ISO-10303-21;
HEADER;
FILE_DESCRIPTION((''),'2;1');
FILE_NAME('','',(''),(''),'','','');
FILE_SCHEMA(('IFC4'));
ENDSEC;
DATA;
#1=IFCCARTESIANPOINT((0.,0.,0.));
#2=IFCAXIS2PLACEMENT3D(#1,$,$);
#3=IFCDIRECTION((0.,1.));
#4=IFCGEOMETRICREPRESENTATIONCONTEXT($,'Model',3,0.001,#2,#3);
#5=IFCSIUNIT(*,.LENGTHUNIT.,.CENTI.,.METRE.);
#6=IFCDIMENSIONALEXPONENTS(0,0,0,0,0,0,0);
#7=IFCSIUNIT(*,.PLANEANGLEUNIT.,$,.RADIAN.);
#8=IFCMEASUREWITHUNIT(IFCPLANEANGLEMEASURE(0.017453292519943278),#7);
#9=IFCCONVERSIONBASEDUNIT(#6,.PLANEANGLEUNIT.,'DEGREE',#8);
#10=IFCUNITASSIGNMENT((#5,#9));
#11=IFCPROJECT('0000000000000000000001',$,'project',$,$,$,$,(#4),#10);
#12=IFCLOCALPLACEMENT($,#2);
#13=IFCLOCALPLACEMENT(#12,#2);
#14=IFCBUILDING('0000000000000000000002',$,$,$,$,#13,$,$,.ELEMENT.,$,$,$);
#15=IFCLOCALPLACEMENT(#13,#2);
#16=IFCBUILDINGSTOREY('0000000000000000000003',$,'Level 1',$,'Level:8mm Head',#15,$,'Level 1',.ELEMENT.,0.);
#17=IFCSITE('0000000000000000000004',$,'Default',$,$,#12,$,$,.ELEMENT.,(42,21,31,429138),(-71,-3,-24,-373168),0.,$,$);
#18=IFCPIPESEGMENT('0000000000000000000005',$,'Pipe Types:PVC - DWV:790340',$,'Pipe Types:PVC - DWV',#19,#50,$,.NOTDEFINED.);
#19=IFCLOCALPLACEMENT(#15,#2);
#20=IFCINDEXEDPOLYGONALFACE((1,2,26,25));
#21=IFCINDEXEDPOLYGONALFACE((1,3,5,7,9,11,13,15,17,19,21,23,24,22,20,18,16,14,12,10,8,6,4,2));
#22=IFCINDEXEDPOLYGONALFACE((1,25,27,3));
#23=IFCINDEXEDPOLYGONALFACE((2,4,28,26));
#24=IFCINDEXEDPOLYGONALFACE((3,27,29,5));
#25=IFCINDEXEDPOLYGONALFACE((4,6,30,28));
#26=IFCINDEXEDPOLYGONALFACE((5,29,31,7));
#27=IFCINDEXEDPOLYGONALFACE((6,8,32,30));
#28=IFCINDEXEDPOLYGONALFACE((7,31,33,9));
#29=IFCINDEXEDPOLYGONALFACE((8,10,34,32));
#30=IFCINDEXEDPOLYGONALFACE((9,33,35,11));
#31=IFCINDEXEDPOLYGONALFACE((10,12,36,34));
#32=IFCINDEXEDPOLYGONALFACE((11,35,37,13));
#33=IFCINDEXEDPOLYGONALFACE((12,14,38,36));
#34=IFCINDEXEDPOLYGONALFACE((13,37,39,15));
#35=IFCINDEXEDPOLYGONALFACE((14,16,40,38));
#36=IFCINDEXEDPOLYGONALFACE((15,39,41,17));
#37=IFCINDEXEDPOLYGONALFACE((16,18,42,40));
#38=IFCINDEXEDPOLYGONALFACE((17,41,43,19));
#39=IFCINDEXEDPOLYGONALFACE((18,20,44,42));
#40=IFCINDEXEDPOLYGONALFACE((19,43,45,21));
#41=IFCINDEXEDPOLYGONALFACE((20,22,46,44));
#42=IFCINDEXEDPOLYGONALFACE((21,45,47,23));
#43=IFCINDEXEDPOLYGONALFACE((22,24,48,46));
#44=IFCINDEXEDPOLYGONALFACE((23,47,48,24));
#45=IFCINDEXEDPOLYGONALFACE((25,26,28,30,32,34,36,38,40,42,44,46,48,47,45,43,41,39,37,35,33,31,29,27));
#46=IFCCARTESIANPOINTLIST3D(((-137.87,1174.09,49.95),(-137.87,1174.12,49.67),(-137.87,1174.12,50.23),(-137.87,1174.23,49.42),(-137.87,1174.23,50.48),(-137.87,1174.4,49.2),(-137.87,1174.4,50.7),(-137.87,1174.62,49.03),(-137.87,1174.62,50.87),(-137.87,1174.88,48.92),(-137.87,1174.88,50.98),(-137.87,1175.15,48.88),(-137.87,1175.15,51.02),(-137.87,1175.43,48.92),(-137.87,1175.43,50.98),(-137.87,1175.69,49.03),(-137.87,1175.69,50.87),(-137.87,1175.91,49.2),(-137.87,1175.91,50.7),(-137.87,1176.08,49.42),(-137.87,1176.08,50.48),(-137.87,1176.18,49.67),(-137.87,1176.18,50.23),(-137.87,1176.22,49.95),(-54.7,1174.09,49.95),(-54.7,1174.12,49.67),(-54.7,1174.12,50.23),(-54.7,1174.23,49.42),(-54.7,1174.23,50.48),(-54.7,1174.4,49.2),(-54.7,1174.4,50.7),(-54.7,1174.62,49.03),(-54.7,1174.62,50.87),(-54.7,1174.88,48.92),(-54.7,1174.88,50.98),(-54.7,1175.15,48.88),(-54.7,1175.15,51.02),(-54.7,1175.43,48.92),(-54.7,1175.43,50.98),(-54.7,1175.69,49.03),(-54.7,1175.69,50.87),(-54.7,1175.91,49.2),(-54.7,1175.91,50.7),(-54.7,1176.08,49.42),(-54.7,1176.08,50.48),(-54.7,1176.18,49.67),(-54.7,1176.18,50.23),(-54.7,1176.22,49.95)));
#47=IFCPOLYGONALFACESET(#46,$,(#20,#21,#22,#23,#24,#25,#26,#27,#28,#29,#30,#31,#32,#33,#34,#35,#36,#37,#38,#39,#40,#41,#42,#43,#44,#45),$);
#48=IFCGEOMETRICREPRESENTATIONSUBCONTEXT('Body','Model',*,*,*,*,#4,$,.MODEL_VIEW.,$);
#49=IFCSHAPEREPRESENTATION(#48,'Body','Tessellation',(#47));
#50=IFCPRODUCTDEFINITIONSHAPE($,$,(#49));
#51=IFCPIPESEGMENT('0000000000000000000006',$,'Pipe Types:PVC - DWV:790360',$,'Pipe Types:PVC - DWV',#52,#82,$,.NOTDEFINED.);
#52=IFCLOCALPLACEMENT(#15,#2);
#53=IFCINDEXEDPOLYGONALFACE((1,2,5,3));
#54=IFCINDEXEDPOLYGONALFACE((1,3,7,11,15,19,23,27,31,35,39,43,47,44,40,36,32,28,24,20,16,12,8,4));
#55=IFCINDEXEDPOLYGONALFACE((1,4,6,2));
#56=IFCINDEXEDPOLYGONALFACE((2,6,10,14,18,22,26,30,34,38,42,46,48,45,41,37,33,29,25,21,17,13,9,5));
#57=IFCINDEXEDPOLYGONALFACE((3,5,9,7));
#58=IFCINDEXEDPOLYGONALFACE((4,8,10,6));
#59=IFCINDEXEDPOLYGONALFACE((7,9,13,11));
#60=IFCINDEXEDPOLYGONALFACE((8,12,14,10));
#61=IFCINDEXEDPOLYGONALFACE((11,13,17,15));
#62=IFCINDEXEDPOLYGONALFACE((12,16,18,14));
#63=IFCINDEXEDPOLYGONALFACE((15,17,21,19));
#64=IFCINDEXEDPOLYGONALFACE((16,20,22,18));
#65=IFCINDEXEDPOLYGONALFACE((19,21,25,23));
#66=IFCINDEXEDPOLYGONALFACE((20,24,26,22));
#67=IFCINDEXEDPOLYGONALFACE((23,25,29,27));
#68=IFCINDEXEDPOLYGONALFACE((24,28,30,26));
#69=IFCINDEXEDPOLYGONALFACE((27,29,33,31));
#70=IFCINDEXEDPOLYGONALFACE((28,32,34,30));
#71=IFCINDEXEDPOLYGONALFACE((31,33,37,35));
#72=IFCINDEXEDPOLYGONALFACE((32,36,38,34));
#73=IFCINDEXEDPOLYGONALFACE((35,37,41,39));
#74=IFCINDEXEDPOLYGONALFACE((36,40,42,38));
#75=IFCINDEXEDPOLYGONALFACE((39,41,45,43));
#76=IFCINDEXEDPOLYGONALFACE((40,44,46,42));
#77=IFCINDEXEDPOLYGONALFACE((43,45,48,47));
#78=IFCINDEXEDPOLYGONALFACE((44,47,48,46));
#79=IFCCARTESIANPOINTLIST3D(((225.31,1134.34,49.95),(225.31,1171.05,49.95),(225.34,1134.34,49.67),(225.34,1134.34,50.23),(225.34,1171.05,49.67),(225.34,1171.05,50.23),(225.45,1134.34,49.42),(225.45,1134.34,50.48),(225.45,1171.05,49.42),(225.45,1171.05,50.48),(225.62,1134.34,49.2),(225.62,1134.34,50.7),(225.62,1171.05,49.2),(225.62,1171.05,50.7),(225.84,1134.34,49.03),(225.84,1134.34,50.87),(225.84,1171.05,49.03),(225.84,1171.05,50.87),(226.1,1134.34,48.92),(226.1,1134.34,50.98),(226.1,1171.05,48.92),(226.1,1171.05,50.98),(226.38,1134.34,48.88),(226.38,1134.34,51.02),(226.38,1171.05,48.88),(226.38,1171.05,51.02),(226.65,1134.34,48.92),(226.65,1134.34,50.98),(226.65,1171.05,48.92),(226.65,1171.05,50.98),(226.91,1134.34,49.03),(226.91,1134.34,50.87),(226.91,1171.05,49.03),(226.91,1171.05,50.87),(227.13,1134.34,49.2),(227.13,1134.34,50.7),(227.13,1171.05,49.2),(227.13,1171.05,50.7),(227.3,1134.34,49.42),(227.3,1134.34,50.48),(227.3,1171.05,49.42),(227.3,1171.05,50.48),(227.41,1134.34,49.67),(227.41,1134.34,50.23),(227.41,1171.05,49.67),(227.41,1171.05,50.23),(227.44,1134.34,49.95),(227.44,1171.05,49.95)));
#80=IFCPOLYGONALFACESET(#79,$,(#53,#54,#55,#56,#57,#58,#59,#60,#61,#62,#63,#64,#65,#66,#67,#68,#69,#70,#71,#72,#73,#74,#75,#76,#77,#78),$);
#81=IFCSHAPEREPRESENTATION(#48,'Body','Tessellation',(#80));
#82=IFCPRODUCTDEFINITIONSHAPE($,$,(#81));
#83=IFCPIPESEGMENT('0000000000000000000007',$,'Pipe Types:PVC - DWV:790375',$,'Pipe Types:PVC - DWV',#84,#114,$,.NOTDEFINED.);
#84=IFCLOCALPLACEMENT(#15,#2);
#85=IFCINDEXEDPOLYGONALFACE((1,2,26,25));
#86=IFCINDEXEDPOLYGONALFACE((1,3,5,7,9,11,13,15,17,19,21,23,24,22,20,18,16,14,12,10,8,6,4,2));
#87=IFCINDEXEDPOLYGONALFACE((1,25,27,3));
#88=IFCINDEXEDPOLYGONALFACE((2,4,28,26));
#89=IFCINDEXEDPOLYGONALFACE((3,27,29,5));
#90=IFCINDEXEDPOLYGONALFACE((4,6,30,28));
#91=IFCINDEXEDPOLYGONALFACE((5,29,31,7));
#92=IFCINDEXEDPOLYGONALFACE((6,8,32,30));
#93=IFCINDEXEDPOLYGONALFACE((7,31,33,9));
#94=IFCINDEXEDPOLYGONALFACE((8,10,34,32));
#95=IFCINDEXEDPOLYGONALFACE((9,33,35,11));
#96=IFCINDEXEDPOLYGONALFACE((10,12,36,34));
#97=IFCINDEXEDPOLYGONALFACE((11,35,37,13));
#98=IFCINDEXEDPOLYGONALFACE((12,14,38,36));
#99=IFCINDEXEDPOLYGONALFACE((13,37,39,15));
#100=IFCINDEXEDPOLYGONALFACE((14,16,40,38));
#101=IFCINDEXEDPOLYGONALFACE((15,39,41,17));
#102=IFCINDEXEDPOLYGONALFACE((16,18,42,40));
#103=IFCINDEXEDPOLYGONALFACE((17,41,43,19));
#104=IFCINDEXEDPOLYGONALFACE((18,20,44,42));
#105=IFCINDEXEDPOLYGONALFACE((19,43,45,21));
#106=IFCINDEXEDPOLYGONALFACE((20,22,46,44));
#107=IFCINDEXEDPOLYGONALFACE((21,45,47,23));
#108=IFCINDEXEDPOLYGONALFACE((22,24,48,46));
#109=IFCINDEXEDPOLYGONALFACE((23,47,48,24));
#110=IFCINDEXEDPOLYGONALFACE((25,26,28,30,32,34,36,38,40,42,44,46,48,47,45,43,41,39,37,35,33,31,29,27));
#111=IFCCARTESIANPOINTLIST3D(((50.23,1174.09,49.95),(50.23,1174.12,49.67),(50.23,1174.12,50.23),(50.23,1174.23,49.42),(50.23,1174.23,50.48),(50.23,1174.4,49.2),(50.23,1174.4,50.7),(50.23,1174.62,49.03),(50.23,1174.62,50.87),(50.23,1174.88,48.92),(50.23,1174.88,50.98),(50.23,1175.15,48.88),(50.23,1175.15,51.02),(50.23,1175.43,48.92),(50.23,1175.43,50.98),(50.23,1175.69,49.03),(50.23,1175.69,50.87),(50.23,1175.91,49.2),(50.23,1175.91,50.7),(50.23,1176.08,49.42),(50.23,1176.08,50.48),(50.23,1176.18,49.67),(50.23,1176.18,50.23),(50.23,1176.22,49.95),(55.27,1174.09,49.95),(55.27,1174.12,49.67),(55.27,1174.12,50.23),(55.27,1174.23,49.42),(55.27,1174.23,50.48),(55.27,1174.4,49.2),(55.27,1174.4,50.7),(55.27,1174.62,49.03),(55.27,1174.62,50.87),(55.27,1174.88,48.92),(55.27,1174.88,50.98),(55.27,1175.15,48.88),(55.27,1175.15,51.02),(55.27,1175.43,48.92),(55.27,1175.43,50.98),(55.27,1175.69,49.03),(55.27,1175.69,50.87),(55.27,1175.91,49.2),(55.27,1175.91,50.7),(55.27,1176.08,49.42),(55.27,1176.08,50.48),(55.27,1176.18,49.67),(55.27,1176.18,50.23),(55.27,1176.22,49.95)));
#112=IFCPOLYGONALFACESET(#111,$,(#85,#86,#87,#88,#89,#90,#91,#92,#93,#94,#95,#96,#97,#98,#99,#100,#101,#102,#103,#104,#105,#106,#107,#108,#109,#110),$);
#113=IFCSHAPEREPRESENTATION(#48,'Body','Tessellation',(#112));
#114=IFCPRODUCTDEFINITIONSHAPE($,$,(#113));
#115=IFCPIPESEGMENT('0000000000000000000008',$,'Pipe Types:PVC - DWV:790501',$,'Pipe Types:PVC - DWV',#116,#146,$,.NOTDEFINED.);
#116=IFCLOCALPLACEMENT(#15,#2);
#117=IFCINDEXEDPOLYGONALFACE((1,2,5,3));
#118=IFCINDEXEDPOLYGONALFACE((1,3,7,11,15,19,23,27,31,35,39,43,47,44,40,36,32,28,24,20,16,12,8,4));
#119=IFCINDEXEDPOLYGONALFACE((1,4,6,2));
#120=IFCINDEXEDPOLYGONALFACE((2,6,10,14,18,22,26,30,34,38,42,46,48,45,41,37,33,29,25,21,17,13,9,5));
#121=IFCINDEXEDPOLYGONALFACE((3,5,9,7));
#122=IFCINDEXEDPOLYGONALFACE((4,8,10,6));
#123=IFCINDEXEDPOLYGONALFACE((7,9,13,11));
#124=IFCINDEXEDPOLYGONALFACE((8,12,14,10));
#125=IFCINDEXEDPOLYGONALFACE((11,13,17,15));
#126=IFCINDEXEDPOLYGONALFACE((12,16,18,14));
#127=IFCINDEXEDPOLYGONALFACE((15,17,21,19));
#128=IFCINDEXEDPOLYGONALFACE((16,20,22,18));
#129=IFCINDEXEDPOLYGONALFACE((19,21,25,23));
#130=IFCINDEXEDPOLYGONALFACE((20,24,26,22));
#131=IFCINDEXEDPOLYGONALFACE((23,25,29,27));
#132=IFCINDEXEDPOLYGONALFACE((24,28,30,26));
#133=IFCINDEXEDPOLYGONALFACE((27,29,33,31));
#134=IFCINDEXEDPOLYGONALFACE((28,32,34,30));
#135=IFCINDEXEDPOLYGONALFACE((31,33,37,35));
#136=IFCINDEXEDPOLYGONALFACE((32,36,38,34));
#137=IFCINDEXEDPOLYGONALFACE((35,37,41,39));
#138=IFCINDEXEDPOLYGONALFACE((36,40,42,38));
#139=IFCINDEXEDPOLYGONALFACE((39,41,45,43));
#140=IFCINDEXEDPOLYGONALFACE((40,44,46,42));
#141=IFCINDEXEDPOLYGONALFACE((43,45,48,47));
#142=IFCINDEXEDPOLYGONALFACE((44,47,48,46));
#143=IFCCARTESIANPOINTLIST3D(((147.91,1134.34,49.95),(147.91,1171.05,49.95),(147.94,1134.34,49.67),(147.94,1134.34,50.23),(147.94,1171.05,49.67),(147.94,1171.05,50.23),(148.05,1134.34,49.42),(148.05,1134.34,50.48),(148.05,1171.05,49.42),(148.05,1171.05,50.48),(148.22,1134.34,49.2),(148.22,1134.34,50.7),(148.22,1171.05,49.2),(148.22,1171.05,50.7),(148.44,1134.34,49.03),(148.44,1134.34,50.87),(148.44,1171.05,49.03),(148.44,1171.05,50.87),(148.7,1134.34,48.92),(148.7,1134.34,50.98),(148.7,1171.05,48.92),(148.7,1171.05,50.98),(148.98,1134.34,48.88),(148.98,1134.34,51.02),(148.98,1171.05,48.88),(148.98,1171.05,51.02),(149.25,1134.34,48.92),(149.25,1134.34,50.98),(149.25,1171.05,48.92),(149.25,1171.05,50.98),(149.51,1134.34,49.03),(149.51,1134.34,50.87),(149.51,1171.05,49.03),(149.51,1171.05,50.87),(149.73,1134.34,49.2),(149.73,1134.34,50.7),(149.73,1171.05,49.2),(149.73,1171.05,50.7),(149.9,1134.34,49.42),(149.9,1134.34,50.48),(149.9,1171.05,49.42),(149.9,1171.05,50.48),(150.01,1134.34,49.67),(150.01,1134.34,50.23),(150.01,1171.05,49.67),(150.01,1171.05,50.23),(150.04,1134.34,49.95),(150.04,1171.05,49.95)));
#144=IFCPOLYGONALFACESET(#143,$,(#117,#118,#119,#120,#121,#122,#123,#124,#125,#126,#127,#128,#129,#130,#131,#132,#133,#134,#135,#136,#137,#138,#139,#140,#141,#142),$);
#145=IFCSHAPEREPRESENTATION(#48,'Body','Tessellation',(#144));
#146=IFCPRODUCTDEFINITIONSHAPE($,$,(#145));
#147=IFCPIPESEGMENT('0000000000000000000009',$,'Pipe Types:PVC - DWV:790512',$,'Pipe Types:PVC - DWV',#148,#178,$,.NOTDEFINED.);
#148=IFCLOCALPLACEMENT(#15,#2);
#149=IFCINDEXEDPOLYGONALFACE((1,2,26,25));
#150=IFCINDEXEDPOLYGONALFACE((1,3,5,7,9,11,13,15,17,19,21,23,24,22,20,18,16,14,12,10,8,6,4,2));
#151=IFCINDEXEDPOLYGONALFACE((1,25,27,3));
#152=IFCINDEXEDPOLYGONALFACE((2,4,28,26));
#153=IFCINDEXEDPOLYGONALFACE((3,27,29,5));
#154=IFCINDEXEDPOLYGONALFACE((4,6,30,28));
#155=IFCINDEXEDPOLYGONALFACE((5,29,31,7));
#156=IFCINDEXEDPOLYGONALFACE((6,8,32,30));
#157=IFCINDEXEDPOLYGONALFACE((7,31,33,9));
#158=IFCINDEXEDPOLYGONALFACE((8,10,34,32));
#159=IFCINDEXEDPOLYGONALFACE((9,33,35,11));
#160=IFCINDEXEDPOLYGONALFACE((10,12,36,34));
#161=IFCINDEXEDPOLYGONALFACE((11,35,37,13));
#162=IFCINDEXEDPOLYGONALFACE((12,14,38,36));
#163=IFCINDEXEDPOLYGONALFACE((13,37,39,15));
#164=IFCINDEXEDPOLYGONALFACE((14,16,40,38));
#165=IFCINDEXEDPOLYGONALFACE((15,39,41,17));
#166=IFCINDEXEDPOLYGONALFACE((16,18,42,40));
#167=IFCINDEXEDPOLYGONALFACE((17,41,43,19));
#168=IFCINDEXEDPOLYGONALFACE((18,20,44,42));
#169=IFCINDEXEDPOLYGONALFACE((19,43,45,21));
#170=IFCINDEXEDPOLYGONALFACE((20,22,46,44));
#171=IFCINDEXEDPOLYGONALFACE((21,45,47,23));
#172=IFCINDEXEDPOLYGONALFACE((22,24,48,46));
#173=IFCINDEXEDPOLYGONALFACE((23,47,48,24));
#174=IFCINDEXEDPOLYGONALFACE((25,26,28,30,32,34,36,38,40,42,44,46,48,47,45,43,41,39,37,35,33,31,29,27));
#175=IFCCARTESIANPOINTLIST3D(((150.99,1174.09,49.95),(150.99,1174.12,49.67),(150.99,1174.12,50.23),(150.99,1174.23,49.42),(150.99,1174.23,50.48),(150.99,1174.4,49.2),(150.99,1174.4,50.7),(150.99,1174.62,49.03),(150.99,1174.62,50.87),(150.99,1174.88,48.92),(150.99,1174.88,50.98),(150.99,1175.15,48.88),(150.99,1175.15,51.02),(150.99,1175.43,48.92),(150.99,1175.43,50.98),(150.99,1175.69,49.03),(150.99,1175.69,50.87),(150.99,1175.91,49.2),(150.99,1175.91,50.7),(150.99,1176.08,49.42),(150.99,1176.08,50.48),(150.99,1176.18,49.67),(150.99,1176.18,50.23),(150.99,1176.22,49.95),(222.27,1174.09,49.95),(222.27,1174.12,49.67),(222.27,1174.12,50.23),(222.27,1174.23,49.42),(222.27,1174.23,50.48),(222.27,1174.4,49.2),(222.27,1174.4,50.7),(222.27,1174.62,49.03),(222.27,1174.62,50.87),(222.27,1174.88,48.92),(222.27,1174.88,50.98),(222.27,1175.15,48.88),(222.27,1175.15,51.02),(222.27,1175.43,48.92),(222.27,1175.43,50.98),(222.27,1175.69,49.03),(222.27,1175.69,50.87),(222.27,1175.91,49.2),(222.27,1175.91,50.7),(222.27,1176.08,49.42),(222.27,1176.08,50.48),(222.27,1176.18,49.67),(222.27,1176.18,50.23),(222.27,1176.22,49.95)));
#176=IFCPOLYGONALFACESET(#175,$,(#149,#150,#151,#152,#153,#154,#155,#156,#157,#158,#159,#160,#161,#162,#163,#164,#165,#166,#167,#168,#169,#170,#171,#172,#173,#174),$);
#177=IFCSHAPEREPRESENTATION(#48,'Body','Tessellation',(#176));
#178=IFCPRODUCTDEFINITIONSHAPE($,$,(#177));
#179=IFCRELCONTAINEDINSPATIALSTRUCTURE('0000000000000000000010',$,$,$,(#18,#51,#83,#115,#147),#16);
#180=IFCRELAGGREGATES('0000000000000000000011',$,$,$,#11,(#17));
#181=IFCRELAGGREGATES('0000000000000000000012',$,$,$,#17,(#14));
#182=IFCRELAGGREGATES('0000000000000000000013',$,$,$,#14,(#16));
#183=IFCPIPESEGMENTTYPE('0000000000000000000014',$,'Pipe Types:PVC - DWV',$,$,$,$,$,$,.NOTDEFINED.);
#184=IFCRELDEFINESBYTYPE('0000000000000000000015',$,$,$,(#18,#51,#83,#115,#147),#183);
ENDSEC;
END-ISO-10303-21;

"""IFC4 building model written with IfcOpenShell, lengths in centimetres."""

from ifc_helpers import new_model, entity, si_unit, converted_unit, direction, frame, origin, place, context, subcontext, project, spatial, arc, indexed_curve, outline, extrude, type_object, element, save


model = new_model("IFC4")

# Units and contexts
model_context = context("Model", 3, precision=0.001, world=origin(), true_north=direction((0.0, 1.0)))
body_context = subcontext(model_context, "Body", "Model", "MODEL_VIEW")
ifc_project = project(units=[si_unit("LENGTHUNIT", "METRE", prefix="CENTI"), converted_unit("PLANEANGLEUNIT", "DEGREE", entity("IfcPlaneAngleMeasure", 0.017453292519943278), si_unit("PLANEANGLEUNIT", "RADIAN"), dimensions=[0, 0, 0, 0, 0, 0, 0])], contexts=[model_context])

# Site, building, storey
site_placement = place(None, origin())
site = spatial("IfcSite", under=ifc_project, at=site_placement, Name="Default", CompositionType="ELEMENT", RefLatitude=(42, 21, 31, 429138), RefLongitude=(-71, -3, -24, -373168), RefElevation=0.0)
building_placement = place(site_placement, origin())
building = spatial("IfcBuilding", under=site, at=building_placement, CompositionType="ELEMENT")
storey_placement = place(building_placement, origin())
storey = spatial("IfcBuildingStorey", under=building, at=storey_placement, Name="Level 1", ObjectType="Level:8mm Head", LongName="Level 1", CompositionType="ELEMENT", Elevation=0.0)

# Pipe segments
pipe_segment_type = type_object("IfcPipeSegmentType", Name="Pipe Types:PVC - DWV", PredefinedType="NOTDEFINED")
pipe_segment_1_placement = place(storey_placement, origin())
element("IfcPipeSegment", 1, at=pipe_segment_1_placement, inside=storey, type_object=pipe_segment_type, Name="Pipe Types:PVC - DWV:790340", ObjectType="Pipe Types:PVC - DWV", PredefinedType="NOTDEFINED", context=body_context, shape_type="SweptSolid", body=[
    extrude(outline(indexed_curve([(1.07, 0.0), (0.75, 0.75), (0.0, 1.07), (-0.75, 0.75), (-1.07, 0.0), (-0.75, -0.75), (0.0, -1.07), (0.75, -0.75)], segments=[arc(1, 2, 3), arc(3, 4, 5), arc(5, 6, 7), arc(7, 8, 1)], self_intersect=False)), frame((-137.87, 1175.15, 49.95), z_axis=(1.0, 0.0, 0.0), x_axis=(0.0, -1.0, 0.0)), (0.0, 0.0, 1.0), 83.17),
])
pipe_segment_2_placement = place(storey_placement, origin())
element("IfcPipeSegment", 2, at=pipe_segment_2_placement, inside=storey, type_object=pipe_segment_type, Name="Pipe Types:PVC - DWV:790360", ObjectType="Pipe Types:PVC - DWV", PredefinedType="NOTDEFINED", context=body_context, shape_type="SweptSolid", body=[
    extrude(outline(indexed_curve([(1.07, 0.0), (0.75, 0.75), (0.0, 1.07), (-0.75, 0.75), (-1.07, 0.0), (-0.75, -0.75), (0.0, -1.07), (0.75, -0.75)], segments=[arc(1, 2, 3), arc(3, 4, 5), arc(5, 6, 7), arc(7, 8, 1)], self_intersect=False)), frame((226.38, 1134.34, 49.95), z_axis=(0.0, 1.0, 0.0), x_axis=(-1.0, 0.0, 0.0)), (0.0, 0.0, 1.0), 36.71),
])
pipe_segment_3_placement = place(storey_placement, origin())
element("IfcPipeSegment", 3, at=pipe_segment_3_placement, inside=storey, type_object=pipe_segment_type, Name="Pipe Types:PVC - DWV:790375", ObjectType="Pipe Types:PVC - DWV", PredefinedType="NOTDEFINED", context=body_context, shape_type="SweptSolid", body=[
    extrude(outline(indexed_curve([(1.07, 0.0), (0.75, 0.75), (0.0, 1.07), (-0.75, 0.75), (-1.07, 0.0), (-0.75, -0.75), (0.0, -1.07), (0.75, -0.75)], segments=[arc(1, 2, 3), arc(3, 4, 5), arc(5, 6, 7), arc(7, 8, 1)], self_intersect=False)), frame((50.23, 1175.15, 49.95), z_axis=(1.0, 0.0, 0.0), x_axis=(0.0, 1.0, 0.0)), (0.0, 0.0, 1.0), 5.04),
])
pipe_segment_4_placement = place(storey_placement, origin())
element("IfcPipeSegment", 4, at=pipe_segment_4_placement, inside=storey, type_object=pipe_segment_type, Name="Pipe Types:PVC - DWV:790501", ObjectType="Pipe Types:PVC - DWV", PredefinedType="NOTDEFINED", context=body_context, shape_type="SweptSolid", body=[
    extrude(outline(indexed_curve([(1.07, 0.0), (0.75, 0.75), (0.0, 1.07), (-0.75, 0.75), (-1.07, 0.0), (-0.75, -0.75), (0.0, -1.07), (0.75, -0.75)], segments=[arc(1, 2, 3), arc(3, 4, 5), arc(5, 6, 7), arc(7, 8, 1)], self_intersect=False)), frame((148.98, 1134.34, 49.95), z_axis=(0.0, 1.0, 0.0), x_axis=(-1.0, 0.0, 0.0)), (0.0, 0.0, 1.0), 36.71),
])
pipe_segment_5_placement = place(storey_placement, origin())
element("IfcPipeSegment", 5, at=pipe_segment_5_placement, inside=storey, type_object=pipe_segment_type, Name="Pipe Types:PVC - DWV:790512", ObjectType="Pipe Types:PVC - DWV", PredefinedType="NOTDEFINED", context=body_context, shape_type="SweptSolid", body=[
    extrude(outline(indexed_curve([(1.07, 0.0), (0.75, 0.75), (0.0, 1.07), (-0.75, 0.75), (-1.07, 0.0), (-0.75, -0.75), (0.0, -1.07), (0.75, -0.75)], segments=[arc(1, 2, 3), arc(3, 4, 5), arc(5, 6, 7), arc(7, 8, 1)], self_intersect=False)), frame((150.99, 1175.15, 49.95), z_axis=(1.0, 0.0, 0.0), x_axis=(0.0, 1.0, 0.0)), (0.0, 0.0, 1.0), 71.29),
])

save(model, "model.ifc")
